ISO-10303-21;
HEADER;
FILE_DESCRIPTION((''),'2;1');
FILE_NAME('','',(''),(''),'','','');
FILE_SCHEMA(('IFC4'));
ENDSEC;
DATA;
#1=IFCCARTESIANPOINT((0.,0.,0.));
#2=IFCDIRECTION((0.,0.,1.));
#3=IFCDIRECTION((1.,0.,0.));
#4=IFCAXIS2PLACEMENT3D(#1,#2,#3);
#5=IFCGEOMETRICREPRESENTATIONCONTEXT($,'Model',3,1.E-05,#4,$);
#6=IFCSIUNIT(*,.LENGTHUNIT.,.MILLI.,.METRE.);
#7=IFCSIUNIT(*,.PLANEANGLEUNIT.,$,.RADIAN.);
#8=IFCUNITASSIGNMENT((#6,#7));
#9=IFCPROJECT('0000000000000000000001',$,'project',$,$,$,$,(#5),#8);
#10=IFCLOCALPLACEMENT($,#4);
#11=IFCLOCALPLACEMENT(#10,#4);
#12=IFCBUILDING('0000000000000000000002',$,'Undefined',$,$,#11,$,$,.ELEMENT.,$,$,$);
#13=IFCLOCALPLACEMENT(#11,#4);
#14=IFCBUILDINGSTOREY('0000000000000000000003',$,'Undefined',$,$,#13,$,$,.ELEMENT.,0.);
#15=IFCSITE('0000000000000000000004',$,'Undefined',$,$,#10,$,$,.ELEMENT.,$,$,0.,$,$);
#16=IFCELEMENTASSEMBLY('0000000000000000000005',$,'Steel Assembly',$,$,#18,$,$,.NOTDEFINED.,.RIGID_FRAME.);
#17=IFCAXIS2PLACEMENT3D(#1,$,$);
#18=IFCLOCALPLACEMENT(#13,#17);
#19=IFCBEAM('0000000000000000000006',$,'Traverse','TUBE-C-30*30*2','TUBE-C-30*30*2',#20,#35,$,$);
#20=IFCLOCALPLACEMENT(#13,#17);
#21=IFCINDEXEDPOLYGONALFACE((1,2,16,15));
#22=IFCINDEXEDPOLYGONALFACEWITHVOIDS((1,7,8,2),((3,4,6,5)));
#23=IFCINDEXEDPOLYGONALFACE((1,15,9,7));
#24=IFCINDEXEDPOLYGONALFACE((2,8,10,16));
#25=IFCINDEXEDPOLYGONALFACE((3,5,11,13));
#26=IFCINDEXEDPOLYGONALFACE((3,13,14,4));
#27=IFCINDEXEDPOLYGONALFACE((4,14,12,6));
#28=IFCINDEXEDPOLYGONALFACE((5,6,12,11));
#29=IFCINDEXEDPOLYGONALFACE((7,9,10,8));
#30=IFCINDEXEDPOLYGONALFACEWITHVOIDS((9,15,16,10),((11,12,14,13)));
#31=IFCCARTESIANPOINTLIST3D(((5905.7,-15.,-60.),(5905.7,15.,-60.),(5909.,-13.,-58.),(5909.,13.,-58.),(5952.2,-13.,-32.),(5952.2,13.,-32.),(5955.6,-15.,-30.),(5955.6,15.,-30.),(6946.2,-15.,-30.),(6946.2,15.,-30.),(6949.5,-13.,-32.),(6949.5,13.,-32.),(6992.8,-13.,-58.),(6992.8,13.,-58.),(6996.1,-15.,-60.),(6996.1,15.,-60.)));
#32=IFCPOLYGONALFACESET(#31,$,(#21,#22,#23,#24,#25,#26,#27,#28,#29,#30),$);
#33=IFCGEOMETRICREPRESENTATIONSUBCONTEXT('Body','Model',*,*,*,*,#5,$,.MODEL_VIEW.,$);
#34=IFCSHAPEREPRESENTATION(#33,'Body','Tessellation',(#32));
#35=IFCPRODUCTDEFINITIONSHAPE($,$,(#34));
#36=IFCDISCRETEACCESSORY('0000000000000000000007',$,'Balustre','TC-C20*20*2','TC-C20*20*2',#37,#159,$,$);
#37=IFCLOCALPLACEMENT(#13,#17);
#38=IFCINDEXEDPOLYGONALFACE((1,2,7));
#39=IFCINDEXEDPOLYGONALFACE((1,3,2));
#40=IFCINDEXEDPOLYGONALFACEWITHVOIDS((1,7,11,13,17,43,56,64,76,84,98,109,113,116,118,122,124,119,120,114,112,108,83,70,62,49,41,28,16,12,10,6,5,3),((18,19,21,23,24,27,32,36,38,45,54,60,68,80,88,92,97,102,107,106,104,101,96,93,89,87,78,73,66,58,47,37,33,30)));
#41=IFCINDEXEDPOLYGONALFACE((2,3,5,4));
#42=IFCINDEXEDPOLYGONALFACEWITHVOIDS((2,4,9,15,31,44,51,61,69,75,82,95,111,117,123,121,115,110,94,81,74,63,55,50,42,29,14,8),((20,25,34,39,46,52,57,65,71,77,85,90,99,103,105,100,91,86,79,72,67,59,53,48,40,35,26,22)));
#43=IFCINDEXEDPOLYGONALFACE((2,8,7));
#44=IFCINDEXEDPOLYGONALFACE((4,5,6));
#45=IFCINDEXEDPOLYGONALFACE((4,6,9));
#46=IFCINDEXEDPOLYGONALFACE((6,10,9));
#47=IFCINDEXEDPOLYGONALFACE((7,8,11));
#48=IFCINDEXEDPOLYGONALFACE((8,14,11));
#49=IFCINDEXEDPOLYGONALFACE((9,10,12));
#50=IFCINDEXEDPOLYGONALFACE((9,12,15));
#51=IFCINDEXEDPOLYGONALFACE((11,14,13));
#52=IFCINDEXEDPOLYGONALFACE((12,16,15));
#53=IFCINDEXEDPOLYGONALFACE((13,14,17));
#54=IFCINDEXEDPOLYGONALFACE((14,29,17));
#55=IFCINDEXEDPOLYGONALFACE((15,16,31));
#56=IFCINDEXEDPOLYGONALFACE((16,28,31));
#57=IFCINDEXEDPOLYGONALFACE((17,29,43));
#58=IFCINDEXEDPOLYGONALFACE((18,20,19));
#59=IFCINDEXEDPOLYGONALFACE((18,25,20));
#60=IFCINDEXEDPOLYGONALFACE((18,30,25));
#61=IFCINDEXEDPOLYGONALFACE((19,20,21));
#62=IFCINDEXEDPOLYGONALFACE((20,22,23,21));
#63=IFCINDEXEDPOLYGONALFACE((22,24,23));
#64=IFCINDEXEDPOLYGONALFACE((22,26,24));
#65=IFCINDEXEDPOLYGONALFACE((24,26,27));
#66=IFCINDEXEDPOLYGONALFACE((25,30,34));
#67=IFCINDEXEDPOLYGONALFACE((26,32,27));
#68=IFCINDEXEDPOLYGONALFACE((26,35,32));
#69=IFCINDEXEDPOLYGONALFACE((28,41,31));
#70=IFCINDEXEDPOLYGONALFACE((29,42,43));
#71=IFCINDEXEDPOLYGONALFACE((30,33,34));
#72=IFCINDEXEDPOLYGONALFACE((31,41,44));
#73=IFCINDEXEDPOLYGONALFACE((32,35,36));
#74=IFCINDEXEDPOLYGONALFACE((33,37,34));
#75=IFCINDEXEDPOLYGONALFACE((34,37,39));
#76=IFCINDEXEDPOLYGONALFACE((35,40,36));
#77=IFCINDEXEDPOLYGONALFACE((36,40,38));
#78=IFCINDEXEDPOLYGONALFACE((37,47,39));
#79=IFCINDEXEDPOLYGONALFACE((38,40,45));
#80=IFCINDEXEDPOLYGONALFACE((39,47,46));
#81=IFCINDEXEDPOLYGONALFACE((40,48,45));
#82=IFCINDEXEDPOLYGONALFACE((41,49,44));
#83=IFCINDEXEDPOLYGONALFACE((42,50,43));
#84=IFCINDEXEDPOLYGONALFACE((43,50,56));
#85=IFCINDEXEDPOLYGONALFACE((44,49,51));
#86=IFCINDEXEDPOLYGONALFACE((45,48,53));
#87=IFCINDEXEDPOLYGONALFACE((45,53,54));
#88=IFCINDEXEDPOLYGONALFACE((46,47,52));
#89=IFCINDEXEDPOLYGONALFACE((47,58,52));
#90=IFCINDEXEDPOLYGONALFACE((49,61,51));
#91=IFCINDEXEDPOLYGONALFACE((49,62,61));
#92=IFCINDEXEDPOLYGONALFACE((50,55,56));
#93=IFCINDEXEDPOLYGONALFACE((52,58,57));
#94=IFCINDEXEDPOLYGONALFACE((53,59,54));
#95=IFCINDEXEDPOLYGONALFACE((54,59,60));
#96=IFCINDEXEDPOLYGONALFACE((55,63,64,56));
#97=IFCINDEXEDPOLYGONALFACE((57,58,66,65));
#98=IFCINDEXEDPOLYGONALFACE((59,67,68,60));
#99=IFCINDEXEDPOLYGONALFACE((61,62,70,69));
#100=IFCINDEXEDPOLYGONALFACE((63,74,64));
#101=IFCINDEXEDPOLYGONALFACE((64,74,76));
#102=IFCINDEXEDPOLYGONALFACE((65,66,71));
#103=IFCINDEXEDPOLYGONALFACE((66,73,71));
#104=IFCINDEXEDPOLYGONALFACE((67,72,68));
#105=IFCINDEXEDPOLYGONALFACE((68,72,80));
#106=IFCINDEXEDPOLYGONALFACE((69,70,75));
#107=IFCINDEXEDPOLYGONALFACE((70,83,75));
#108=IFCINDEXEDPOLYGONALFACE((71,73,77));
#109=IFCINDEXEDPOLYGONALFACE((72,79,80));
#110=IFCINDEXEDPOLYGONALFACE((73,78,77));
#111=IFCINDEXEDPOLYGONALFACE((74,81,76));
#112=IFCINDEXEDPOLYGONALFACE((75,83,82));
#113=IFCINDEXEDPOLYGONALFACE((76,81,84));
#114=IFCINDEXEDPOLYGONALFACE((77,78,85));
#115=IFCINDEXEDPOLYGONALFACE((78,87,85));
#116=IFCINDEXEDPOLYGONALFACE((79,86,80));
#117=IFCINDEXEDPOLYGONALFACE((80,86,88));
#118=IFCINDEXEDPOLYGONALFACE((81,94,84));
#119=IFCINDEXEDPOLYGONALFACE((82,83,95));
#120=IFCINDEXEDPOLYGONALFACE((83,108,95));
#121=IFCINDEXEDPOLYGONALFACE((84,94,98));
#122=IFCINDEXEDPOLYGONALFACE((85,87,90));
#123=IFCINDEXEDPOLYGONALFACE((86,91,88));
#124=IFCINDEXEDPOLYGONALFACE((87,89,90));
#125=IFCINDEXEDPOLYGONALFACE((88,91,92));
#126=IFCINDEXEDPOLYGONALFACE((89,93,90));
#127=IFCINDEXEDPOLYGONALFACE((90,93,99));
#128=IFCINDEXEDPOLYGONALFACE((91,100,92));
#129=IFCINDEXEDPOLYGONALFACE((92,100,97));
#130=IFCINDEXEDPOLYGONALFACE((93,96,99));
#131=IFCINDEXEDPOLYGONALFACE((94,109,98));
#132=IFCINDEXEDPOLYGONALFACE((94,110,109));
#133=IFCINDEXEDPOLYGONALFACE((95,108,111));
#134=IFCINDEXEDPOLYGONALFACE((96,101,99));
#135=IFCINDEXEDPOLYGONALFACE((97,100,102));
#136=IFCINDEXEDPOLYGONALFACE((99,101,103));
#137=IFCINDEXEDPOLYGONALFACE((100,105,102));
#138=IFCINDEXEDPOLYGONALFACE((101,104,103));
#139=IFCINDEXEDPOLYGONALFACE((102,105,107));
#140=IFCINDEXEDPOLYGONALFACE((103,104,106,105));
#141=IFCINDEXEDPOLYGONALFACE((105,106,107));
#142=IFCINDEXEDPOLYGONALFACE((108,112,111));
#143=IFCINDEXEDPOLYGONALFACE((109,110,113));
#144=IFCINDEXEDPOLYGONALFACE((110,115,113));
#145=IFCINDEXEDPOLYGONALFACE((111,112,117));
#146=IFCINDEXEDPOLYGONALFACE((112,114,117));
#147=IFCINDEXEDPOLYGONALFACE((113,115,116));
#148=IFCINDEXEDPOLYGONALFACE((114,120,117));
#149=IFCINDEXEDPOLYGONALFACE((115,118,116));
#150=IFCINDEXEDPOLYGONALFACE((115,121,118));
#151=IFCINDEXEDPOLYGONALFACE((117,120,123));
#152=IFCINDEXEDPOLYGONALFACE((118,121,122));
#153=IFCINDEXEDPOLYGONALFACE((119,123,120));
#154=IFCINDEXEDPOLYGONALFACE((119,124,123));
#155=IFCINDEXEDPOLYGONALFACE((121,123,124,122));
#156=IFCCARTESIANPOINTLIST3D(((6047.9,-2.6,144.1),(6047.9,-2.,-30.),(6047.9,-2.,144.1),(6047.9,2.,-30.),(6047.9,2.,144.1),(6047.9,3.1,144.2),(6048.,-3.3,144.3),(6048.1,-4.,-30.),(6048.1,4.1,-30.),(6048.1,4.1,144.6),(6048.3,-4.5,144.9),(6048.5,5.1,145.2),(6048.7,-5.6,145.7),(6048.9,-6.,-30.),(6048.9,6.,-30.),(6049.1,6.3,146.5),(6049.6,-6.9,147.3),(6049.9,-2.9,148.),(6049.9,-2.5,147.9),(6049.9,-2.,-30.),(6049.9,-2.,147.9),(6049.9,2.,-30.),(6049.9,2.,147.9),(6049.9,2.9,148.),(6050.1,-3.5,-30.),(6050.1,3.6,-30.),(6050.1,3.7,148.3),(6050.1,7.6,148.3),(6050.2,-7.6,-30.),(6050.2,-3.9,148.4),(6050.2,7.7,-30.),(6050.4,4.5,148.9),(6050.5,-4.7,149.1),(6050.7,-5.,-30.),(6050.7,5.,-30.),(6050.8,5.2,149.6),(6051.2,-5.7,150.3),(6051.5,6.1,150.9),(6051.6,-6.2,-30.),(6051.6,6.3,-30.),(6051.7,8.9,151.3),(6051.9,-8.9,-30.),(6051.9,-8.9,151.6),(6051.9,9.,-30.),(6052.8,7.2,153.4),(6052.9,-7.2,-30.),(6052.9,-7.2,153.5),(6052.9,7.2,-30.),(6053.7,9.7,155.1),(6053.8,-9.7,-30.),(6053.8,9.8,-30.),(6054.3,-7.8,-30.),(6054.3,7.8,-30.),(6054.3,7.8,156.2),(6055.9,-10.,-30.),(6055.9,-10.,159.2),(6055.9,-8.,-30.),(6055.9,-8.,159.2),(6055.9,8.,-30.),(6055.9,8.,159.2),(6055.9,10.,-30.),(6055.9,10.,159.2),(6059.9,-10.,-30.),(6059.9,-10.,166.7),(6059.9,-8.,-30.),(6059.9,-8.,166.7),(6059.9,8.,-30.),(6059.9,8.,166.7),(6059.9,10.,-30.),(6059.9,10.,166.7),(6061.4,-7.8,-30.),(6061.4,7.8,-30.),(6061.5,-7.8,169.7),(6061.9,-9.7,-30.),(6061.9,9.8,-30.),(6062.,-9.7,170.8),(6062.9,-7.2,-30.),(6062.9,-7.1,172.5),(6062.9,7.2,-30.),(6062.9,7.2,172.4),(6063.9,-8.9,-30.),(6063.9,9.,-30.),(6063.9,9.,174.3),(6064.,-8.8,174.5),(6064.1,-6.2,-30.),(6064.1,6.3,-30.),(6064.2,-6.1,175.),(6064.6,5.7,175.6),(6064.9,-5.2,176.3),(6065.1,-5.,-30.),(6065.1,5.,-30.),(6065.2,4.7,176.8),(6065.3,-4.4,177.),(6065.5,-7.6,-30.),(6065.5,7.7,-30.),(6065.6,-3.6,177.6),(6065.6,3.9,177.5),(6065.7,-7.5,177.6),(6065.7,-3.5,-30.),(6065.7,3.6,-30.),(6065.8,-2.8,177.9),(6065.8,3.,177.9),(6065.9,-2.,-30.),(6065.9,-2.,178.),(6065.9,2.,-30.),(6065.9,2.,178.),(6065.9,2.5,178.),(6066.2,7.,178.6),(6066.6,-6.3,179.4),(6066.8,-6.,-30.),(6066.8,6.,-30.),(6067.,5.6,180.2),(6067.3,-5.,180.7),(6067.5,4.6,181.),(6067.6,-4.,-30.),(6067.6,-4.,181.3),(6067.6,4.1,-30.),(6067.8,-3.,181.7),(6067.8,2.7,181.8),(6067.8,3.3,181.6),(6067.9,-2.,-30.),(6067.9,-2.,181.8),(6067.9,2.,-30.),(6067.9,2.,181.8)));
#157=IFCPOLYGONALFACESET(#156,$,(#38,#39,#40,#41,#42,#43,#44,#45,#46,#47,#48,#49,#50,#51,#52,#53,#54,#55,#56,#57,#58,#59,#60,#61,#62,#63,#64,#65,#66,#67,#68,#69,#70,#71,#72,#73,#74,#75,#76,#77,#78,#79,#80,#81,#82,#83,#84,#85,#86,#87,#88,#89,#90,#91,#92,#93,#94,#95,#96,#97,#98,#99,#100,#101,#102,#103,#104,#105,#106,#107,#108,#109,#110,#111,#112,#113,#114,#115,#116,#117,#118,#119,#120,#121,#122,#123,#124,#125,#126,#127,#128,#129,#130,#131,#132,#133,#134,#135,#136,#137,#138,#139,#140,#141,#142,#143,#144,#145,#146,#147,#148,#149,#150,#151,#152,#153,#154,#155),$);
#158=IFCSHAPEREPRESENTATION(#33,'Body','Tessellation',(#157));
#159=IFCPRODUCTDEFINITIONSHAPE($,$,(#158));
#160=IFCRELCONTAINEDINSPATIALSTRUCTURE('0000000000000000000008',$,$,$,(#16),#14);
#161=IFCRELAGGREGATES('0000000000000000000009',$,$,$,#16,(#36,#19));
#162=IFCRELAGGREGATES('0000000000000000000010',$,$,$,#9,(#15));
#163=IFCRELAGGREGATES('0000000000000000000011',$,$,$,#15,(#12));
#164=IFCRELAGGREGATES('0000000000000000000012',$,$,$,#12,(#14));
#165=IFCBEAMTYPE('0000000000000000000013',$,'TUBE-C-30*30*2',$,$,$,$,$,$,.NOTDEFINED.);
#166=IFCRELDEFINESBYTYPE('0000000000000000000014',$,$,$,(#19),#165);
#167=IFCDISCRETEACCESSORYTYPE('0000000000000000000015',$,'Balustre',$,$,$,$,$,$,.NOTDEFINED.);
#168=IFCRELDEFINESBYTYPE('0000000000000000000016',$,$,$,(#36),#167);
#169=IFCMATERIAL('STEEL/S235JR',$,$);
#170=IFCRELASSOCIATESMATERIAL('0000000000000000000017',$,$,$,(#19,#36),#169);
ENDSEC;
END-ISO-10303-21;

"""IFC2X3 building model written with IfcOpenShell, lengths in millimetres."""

from ifc_helpers import new_model, si_unit, frame, origin_with_axes, origin_2d_with_axis, place, context, subcontext, project, spatial, hollow_rectangle, extrude, clip, halfspace, material, type_object, element, aggregate, save


model = new_model("IFC2X3")

# Units and contexts
model_context = context("Model", 3, precision=1e-05, world=origin_with_axes())
body_context = subcontext(model_context, "Body", "Model", "MODEL_VIEW")
ifc_project = project(units=[si_unit("LENGTHUNIT", "METRE", prefix="MILLI"), si_unit("PLANEANGLEUNIT", "RADIAN")], contexts=[model_context])

# Site, building, storey
site_placement = place(None, origin_with_axes())
site = spatial("IfcSite", under=ifc_project, at=site_placement, Name="Undefined", CompositionType="ELEMENT", RefElevation=0.0)
building_placement = place(site_placement, origin_with_axes())
building = spatial("IfcBuilding", under=site, at=building_placement, Name="Undefined", CompositionType="ELEMENT")
storey_placement = place(building_placement, origin_with_axes())
storey = spatial("IfcBuildingStorey", under=building, at=storey_placement, Name="Undefined", CompositionType="ELEMENT", Elevation=0.0)

# Element assembly, beam
assembly_1_placement = place(storey_placement, origin_with_axes())
assembly_1 = element("IfcElementAssembly", 1, at=assembly_1_placement, inside=storey, Name="Steel Assembly", AssemblyPlace="NOTDEFINED", PredefinedType="RIGID_FRAME")
ifc_material = material(Name="STEEL/S235JR")
beam_type = type_object("IfcBeamType", Name="TUBE-C-30*30*2", PredefinedType="NOTDEFINED")
beam_1_placement = place(assembly_1_placement, frame((5880.3, 0.0, -45.0), z_axis=(0.000011, -1.0, 0.0), x_axis=(1.0, 0.000011, 0.0)))
beam_1 = element("IfcBeam", 2, at=beam_1_placement, type_object=beam_type, material=ifc_material, Name="Traverse", Description="TUBE-C-30*30*2", ObjectType="TUBE-C-30*30*2", context=body_context, shape_type="Clipping", body=[
    clip(clip(extrude(hollow_rectangle(XDim=30.0, YDim=30.0, WallThickness=2.0, at=origin_2d_with_axis()), frame((1141.2, 0.0, 0.0), z_axis=(-1.0, 0.0, 0.0), x_axis=(0.0, -1.0, 0.0)), (0.0, 0.0, 1.0), 1141.2), halfspace(frame((1065.9, 15.0, 0.0), z_axis=(0.515548, 0.856861, 0.000003), x_axis=(0.000005, 0.0, -1.0)), False)), halfspace(frame((75.3, 15.0, 0.0), z_axis=(0.515548, -0.856861, 0.000003), x_axis=(0.000005, 0.0, -1.0)), True)),
])

# Discrete accessory
discrete_accessory_type_1 = type_object("IfcDiscreteAccessoryType", Name="Balustre")
discrete_accessory_1_placement = place(assembly_1_placement, frame((6057.9, 0.0, -30.0), z_axis=(0.0, 0.0, 1.0), x_axis=(1.0, 0.0, 0.0)))
discrete_accessory_1 = element("IfcDiscreteAccessory", 3, at=discrete_accessory_1_placement, type_object=discrete_accessory_type_1, material=ifc_material, Name="Balustre", Description="TC-C20*20*2", ObjectType="TC-C20*20*2", context=body_context, shape_type="Clipping", body=[
    clip(extrude(hollow_rectangle(XDim=20.0, YDim=20.0, WallThickness=2.0, InnerFilletRadius=6.0, OuterFilletRadius=8.0, at=origin_2d_with_axis()), frame((0.0, 0.0, 212.0), z_axis=(0.0, 0.0, -1.0), x_axis=(-1.0, 0.0, 0.0)), (0.0, 0.0, 1.0), 212.0), halfspace(frame((15.1, 0.0, 221.5), z_axis=(0.883506, 0.000005, -0.46842), x_axis=(-0.000005, 1.0, 0.0)), True)),
])
aggregate(assembly_1, [discrete_accessory_1, beam_1])

save(model, "model.ifc")
